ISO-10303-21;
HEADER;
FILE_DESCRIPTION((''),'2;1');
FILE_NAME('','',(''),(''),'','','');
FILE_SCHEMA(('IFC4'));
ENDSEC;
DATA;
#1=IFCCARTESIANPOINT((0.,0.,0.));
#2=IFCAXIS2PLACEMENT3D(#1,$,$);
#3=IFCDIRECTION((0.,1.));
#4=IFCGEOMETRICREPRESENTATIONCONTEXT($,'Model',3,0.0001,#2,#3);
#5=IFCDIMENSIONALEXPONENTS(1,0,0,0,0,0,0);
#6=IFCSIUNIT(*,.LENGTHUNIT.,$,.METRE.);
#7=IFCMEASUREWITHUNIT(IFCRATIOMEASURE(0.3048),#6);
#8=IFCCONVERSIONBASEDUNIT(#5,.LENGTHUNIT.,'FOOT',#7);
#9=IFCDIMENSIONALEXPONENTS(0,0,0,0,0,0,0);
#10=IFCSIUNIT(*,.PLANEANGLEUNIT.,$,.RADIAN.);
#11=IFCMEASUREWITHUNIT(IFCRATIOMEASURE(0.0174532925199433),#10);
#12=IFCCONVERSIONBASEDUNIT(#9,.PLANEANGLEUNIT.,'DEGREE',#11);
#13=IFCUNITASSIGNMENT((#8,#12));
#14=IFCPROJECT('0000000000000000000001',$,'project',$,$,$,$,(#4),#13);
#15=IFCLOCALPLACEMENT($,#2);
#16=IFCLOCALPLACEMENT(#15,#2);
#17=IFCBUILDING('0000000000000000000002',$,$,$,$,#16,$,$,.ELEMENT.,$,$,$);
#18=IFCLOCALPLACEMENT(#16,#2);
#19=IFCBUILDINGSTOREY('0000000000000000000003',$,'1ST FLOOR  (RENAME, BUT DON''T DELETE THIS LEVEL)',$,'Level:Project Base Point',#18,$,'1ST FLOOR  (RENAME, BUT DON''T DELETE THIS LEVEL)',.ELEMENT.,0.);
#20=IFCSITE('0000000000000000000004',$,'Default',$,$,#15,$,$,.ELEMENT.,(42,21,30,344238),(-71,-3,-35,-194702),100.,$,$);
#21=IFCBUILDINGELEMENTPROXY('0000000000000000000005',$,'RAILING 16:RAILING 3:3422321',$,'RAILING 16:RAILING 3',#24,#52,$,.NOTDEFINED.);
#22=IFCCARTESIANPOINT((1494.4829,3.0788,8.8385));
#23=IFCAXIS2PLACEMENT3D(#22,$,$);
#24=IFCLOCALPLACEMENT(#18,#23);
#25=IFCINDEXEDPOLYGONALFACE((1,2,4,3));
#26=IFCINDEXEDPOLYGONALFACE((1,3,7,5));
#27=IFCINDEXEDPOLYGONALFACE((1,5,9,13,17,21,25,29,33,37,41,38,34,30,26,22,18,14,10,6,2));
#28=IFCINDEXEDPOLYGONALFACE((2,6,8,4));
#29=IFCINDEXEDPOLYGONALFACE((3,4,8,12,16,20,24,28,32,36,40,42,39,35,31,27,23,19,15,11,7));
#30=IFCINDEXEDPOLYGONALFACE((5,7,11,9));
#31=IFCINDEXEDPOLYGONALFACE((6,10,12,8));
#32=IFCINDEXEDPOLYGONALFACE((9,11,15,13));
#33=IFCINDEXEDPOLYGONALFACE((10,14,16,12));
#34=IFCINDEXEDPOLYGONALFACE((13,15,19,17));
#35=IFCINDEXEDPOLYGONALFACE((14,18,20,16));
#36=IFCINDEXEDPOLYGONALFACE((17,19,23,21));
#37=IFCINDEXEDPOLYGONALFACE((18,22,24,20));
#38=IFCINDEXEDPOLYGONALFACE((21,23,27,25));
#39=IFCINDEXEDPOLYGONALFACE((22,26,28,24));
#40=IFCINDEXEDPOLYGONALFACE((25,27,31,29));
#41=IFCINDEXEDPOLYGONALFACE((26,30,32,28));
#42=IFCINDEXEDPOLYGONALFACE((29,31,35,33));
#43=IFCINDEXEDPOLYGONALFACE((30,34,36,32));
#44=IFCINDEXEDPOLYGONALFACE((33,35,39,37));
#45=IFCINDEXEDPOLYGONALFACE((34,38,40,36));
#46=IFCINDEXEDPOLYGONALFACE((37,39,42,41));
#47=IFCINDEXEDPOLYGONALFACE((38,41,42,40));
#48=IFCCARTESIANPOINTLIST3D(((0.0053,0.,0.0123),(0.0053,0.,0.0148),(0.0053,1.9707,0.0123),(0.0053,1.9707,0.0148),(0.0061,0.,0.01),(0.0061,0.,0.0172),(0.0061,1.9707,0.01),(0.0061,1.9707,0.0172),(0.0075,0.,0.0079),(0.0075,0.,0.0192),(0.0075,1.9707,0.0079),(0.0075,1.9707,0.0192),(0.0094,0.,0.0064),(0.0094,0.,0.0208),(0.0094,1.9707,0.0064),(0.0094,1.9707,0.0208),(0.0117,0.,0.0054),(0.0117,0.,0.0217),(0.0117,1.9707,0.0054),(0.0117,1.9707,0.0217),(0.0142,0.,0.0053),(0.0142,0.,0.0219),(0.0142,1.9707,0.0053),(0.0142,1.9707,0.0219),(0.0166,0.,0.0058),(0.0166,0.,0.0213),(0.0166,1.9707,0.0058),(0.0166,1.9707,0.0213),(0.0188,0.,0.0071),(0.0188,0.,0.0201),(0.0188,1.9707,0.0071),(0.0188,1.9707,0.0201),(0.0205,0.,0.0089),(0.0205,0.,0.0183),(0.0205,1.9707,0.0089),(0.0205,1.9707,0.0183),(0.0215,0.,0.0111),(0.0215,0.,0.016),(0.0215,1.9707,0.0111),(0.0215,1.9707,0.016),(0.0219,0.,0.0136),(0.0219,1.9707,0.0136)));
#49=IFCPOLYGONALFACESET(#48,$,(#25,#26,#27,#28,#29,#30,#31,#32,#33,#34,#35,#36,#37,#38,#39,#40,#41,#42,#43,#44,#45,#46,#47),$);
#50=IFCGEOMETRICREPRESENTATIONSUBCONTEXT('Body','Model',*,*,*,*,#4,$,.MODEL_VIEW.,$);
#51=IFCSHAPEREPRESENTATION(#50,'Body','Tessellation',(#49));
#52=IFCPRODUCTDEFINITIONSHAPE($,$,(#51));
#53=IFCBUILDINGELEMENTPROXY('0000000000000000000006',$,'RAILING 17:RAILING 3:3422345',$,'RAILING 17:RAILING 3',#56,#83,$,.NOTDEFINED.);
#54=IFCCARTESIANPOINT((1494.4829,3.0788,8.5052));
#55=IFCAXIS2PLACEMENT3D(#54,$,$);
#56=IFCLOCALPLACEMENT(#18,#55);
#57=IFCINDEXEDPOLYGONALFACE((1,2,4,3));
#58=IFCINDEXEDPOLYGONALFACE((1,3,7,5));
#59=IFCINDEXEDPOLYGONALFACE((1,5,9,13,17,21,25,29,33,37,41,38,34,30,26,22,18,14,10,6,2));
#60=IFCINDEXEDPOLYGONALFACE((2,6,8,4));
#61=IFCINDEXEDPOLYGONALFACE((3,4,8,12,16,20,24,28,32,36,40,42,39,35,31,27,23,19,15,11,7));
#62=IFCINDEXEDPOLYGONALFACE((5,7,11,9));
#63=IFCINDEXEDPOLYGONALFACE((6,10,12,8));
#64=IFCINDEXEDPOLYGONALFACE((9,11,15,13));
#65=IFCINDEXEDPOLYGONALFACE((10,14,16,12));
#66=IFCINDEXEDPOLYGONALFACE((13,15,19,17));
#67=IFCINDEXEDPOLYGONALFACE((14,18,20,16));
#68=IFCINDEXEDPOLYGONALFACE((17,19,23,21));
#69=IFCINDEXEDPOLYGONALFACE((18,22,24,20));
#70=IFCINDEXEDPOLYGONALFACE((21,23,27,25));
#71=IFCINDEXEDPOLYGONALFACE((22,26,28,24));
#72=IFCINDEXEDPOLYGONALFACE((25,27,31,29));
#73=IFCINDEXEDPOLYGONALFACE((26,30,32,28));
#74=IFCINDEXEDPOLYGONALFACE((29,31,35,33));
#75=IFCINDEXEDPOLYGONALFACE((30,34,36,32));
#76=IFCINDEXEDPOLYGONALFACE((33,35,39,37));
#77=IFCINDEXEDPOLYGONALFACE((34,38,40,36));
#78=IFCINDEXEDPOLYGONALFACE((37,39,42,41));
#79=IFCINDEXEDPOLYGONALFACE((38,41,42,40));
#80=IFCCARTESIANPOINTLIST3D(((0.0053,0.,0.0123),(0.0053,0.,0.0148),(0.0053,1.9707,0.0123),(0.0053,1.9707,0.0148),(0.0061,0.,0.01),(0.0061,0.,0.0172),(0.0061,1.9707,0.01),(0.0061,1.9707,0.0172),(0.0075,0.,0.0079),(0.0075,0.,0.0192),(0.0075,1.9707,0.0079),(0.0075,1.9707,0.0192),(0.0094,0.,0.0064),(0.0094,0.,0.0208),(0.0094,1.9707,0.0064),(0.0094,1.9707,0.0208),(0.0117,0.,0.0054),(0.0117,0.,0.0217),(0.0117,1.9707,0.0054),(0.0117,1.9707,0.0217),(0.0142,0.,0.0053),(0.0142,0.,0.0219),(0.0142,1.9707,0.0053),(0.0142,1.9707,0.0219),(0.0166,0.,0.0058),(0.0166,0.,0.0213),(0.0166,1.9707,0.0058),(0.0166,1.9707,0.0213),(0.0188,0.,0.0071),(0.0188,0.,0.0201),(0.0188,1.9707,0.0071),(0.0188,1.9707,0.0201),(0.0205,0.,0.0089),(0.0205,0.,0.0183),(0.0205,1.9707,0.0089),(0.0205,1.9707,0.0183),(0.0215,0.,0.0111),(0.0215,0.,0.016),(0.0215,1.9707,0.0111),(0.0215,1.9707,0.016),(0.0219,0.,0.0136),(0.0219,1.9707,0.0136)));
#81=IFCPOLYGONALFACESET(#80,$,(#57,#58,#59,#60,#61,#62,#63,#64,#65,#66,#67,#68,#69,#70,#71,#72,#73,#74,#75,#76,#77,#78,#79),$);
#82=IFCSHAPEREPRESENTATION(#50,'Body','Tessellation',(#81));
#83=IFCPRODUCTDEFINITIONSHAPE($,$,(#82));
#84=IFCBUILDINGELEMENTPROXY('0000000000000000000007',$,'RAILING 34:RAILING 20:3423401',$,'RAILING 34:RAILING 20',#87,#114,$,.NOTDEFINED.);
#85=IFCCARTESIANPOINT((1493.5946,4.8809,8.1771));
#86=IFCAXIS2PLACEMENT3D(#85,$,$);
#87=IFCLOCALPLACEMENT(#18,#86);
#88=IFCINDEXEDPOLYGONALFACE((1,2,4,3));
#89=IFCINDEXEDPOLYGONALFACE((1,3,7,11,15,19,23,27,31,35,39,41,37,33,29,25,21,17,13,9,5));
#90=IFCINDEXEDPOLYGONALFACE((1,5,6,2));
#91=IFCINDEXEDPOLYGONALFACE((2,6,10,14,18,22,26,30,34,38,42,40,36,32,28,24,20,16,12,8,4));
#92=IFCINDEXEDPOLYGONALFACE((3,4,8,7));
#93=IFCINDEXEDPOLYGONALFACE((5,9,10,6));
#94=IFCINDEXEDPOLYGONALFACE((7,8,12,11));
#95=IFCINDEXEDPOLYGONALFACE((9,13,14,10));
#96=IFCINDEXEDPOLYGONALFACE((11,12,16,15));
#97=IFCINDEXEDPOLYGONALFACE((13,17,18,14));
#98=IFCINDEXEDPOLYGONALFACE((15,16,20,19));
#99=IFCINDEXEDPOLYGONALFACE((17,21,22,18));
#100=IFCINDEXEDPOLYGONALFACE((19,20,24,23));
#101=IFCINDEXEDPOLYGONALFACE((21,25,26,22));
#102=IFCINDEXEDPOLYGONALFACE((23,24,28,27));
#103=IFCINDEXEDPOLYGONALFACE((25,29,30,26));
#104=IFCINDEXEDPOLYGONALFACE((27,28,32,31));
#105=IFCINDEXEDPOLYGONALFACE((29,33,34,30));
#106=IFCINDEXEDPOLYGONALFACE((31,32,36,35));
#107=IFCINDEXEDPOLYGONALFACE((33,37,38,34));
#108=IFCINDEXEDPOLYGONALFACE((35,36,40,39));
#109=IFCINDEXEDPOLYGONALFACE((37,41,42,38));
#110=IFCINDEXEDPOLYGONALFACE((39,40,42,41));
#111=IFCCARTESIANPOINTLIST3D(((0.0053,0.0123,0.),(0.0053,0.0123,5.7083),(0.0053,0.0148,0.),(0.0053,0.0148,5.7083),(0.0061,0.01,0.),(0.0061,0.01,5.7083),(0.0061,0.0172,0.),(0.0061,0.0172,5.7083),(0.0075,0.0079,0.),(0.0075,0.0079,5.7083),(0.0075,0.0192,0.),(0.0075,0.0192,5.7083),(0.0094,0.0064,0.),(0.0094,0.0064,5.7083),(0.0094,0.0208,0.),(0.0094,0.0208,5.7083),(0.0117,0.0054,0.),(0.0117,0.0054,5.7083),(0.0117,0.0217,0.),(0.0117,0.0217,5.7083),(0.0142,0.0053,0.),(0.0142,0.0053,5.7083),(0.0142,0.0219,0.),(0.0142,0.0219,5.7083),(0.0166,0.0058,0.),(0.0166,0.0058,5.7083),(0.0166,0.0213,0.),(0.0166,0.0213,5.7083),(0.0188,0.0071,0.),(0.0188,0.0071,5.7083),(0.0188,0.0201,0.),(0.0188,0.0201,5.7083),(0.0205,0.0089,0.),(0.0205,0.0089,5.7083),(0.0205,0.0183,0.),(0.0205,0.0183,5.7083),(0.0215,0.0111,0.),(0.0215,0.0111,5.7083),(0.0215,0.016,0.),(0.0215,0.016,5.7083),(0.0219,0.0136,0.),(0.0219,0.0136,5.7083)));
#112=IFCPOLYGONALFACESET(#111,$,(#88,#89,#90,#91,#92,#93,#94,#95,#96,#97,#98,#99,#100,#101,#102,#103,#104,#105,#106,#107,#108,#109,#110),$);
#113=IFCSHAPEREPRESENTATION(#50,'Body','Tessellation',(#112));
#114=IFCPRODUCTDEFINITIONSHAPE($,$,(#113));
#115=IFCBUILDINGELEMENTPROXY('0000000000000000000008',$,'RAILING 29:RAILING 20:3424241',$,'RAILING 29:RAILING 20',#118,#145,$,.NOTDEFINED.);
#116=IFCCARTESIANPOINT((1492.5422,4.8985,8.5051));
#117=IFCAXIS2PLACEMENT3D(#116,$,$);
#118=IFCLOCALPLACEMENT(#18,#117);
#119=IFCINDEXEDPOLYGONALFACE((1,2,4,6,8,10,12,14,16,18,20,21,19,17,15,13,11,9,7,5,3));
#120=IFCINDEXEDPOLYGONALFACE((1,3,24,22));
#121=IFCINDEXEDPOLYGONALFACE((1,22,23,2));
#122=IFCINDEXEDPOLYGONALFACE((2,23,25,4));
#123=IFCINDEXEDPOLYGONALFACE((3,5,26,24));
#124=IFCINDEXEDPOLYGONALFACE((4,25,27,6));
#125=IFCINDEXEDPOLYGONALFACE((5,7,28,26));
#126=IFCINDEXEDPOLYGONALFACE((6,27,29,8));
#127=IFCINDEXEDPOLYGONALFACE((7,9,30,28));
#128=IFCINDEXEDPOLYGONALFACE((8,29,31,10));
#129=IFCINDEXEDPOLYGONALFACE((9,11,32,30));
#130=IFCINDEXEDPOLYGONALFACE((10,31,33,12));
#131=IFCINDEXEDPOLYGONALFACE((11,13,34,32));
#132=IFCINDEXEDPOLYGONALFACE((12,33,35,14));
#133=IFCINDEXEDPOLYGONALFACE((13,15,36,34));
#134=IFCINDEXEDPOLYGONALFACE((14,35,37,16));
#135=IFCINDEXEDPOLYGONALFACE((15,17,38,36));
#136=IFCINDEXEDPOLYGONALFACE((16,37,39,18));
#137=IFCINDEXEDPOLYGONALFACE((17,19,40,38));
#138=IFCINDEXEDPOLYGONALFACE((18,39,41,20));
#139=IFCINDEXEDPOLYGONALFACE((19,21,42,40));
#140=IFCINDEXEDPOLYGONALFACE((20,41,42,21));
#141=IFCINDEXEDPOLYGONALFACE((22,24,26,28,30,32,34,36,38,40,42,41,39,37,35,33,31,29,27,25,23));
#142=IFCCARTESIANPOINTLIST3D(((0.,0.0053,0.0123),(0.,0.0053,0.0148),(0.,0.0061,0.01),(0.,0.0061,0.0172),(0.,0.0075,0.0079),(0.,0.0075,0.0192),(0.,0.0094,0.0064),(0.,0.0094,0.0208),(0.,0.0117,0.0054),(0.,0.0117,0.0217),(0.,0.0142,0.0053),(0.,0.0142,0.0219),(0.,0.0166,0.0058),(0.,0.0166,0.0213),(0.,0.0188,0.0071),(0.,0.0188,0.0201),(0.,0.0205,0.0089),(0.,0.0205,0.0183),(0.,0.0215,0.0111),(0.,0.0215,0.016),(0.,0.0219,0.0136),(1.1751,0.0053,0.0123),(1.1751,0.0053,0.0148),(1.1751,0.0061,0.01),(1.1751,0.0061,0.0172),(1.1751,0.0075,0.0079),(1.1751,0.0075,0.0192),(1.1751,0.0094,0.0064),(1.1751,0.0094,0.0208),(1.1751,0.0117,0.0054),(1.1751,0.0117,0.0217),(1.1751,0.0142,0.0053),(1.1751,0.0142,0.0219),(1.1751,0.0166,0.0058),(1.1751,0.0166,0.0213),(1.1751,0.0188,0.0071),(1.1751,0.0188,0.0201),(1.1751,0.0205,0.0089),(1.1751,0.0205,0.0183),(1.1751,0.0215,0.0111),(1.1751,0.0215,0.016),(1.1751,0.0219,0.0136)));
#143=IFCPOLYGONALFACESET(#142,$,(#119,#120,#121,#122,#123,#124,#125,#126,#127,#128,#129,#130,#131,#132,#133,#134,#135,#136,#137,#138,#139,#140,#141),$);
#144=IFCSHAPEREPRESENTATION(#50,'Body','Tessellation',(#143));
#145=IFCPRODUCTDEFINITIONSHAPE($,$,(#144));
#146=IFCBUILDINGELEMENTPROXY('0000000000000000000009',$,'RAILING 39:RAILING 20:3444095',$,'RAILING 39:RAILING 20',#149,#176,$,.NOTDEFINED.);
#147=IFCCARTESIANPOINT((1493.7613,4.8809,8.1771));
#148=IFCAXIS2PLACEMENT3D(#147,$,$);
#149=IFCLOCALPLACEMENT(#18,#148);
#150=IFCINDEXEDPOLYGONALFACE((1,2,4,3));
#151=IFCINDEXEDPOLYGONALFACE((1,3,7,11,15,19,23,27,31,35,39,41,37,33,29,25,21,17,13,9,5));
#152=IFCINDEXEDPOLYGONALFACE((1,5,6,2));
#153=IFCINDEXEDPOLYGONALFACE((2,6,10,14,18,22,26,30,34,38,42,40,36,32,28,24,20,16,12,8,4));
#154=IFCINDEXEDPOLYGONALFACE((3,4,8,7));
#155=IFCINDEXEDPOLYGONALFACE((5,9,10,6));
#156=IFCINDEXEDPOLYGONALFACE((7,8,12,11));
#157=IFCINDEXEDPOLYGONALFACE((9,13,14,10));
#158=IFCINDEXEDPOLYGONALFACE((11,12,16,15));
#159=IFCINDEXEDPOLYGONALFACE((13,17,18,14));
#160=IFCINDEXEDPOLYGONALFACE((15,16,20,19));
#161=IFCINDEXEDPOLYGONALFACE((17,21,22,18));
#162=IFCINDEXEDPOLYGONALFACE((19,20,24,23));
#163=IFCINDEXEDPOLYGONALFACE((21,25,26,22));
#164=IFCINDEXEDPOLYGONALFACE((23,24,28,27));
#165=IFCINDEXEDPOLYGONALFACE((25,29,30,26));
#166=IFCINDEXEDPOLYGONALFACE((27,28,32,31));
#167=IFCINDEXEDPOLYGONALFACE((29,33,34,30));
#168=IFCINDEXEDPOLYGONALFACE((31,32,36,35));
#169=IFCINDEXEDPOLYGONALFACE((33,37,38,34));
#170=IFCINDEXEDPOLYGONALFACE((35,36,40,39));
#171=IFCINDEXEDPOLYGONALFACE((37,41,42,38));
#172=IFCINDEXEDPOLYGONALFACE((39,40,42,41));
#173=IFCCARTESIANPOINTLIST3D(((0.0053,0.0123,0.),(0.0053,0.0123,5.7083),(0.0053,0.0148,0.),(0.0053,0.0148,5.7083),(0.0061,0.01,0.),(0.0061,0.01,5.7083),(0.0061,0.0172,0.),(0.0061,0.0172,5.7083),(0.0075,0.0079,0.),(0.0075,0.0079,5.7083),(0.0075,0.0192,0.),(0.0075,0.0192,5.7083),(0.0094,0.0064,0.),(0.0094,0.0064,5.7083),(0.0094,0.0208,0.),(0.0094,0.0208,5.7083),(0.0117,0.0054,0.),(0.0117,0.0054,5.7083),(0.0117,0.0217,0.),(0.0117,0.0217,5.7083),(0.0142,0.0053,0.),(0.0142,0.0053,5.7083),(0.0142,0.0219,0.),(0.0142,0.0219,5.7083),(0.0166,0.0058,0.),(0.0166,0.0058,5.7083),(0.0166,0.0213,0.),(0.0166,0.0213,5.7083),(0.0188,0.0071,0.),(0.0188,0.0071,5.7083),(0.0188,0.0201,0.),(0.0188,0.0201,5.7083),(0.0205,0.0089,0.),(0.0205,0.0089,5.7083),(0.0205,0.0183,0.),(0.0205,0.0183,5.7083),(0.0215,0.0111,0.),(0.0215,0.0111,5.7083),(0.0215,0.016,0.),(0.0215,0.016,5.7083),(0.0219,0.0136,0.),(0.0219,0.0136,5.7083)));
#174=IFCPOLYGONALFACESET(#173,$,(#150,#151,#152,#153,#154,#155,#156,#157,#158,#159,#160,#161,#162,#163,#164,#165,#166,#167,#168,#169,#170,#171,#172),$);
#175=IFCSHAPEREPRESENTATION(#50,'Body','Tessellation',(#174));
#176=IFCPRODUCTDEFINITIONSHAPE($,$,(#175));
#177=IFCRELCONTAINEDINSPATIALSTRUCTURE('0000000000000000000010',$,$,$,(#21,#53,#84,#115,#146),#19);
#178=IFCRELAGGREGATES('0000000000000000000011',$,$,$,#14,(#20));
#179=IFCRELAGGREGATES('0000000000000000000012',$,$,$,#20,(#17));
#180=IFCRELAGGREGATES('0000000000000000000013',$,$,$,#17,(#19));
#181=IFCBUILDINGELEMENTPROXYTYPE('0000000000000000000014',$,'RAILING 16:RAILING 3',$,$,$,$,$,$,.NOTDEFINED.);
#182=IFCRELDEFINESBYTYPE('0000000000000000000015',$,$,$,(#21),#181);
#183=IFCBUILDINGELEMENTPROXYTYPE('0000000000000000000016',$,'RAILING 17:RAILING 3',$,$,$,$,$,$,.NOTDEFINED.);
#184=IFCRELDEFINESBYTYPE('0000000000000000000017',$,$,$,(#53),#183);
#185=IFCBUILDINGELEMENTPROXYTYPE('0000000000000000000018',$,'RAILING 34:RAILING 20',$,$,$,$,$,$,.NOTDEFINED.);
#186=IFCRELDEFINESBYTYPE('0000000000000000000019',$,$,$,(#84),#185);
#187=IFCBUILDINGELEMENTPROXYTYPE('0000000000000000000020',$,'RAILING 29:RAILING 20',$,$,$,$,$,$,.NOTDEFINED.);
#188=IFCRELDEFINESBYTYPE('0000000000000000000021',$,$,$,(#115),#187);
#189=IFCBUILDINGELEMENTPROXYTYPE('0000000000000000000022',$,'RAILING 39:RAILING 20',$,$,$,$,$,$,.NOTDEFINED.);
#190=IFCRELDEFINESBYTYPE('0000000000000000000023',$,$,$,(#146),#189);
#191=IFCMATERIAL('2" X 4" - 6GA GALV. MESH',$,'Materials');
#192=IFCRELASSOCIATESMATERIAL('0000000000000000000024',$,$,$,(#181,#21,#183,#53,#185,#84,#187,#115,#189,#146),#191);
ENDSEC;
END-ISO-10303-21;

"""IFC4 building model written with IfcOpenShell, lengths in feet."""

from ifc_helpers import new_model, entity, si_unit, converted_unit, direction, frame, origin, origin_2d_with_axis, place, context, subcontext, project, spatial, circle, extrude, source, transform, mapped, material, type_object, type_shapes, element, save


model = new_model("IFC4")

# Units and contexts
model_context = context("Model", 3, precision=0.0001, world=origin(), true_north=direction((0.0, 1.0)))
body_context = subcontext(model_context, "Body", "Model", "MODEL_VIEW")
ifc_project = project(units=[converted_unit("LENGTHUNIT", "FOOT", entity("IfcRatioMeasure", 0.3048), si_unit("LENGTHUNIT", "METRE"), dimensions=[1, 0, 0, 0, 0, 0, 0]), converted_unit("PLANEANGLEUNIT", "DEGREE", entity("IfcRatioMeasure", 0.0174532925199433), si_unit("PLANEANGLEUNIT", "RADIAN"), dimensions=[0, 0, 0, 0, 0, 0, 0])], contexts=[model_context])

# Site, building, storey
site_placement = place(None, origin())
site = spatial("IfcSite", under=ifc_project, at=site_placement, Name="Default", CompositionType="ELEMENT", RefLatitude=(42, 21, 30, 344238), RefLongitude=(-71, -3, -35, -194702), RefElevation=100.0)
building_placement = place(site_placement, origin())
building = spatial("IfcBuilding", under=site, at=building_placement, CompositionType="ELEMENT")
storey_placement = place(building_placement, origin())
storey = spatial("IfcBuildingStorey", under=building, at=storey_placement, Name="1ST FLOOR  (RENAME, BUT DON'T DELETE THIS LEVEL)", ObjectType="Level:Project Base Point", LongName="1ST FLOOR  (RENAME, BUT DON'T DELETE THIS LEVEL)", CompositionType="ELEMENT", Elevation=0.0)

# Building element proxies
ifc_material_1 = material(Name="2\" X 4\" - 6GA GALV. MESH", Category="Materials")
building_element_proxy_type_1 = type_object("IfcBuildingElementProxyType", Name="RAILING 16:RAILING 3", PredefinedType="NOTDEFINED", material=ifc_material_1)
shared_shape_1 = source(origin(), body_context, "Body", "SweptSolid", [
    extrude(circle(Radius=0.0083, at=origin_2d_with_axis()), frame((0.0136, 0.0, 0.0136), z_axis=(0.0, 1.0, 0.0), x_axis=(1.0, 0.0, 0.0)), (0.0, 0.0, 1.0), 1.9707),
])
type_shapes(building_element_proxy_type_1, [shared_shape_1])
proxy_1_placement = place(storey_placement, frame((1494.4829, 3.0788, 8.8385)))
element("IfcBuildingElementProxy", 1, at=proxy_1_placement, inside=storey, type_object=building_element_proxy_type_1, material=ifc_material_1, Name="RAILING 16:RAILING 3:3422321", ObjectType="RAILING 16:RAILING 3", PredefinedType="NOTDEFINED", context=body_context, shape_type="MappedRepresentation", body=[
    mapped(shared_shape_1, transform((0.0, 0.0, 0.0), scale=1.0)),
])
building_element_proxy_type_2 = type_object("IfcBuildingElementProxyType", Name="RAILING 17:RAILING 3", PredefinedType="NOTDEFINED", material=ifc_material_1)
shared_shape_2 = source(origin(), body_context, "Body", "SweptSolid", [
    extrude(circle(Radius=0.0083, at=origin_2d_with_axis()), frame((0.0136, 0.0, 0.0136), z_axis=(0.0, 1.0, 0.0), x_axis=(1.0, 0.0, 0.0)), (0.0, 0.0, 1.0), 1.9707),
])
type_shapes(building_element_proxy_type_2, [shared_shape_2])
proxy_2_placement = place(storey_placement, frame((1494.4829, 3.0788, 8.5052)))
element("IfcBuildingElementProxy", 2, at=proxy_2_placement, inside=storey, type_object=building_element_proxy_type_2, material=ifc_material_1, Name="RAILING 17:RAILING 3:3422345", ObjectType="RAILING 17:RAILING 3", PredefinedType="NOTDEFINED", context=body_context, shape_type="MappedRepresentation", body=[
    mapped(shared_shape_2, transform((0.0, 0.0, 0.0), scale=1.0)),
])
building_element_proxy_type_3 = type_object("IfcBuildingElementProxyType", Name="RAILING 34:RAILING 20", PredefinedType="NOTDEFINED", material=ifc_material_1)
shared_shape_3 = source(origin(), body_context, "Body", "SweptSolid", [
    extrude(circle(Radius=0.0083, at=origin_2d_with_axis()), frame((0.0136, 0.0136, 0.0)), (0.0, 0.0, 1.0), 5.7083),
])
type_shapes(building_element_proxy_type_3, [shared_shape_3])
proxy_3_placement = place(storey_placement, frame((1493.5946, 4.8809, 8.1771)))
element("IfcBuildingElementProxy", 3, at=proxy_3_placement, inside=storey, type_object=building_element_proxy_type_3, material=ifc_material_1, Name="RAILING 34:RAILING 20:3423401", ObjectType="RAILING 34:RAILING 20", PredefinedType="NOTDEFINED", context=body_context, shape_type="MappedRepresentation", body=[
    mapped(shared_shape_3, transform((0.0, 0.0, 0.0), scale=1.0)),
])
building_element_proxy_type_4 = type_object("IfcBuildingElementProxyType", Name="RAILING 29:RAILING 20", PredefinedType="NOTDEFINED", material=ifc_material_1)
shared_shape_4 = source(origin(), body_context, "Body", "SweptSolid", [
    extrude(circle(Radius=0.0083, at=origin_2d_with_axis()), frame((0.0, 0.0136, 0.0136), z_axis=(1.0, 0.0, 0.0), x_axis=(0.0, 1.0, 0.0)), (0.0, 0.0, 1.0), 1.1751),
])
type_shapes(building_element_proxy_type_4, [shared_shape_4])
proxy_4_placement = place(storey_placement, frame((1492.5422, 4.8985, 8.5051)))
element("IfcBuildingElementProxy", 4, at=proxy_4_placement, inside=storey, type_object=building_element_proxy_type_4, material=ifc_material_1, Name="RAILING 29:RAILING 20:3424241", ObjectType="RAILING 29:RAILING 20", PredefinedType="NOTDEFINED", context=body_context, shape_type="MappedRepresentation", body=[
    mapped(shared_shape_4, transform((0.0, 0.0, 0.0), scale=1.0)),
])
building_element_proxy_type_5 = type_object("IfcBuildingElementProxyType", Name="RAILING 39:RAILING 20", PredefinedType="NOTDEFINED", material=ifc_material_1)
shared_shape_5 = source(origin(), body_context, "Body", "SweptSolid", [
    extrude(circle(Radius=0.0083, at=origin_2d_with_axis()), frame((0.0136, 0.0136, 0.0)), (0.0, 0.0, 1.0), 5.7083),
])
type_shapes(building_element_proxy_type_5, [shared_shape_5])
proxy_5_placement = place(storey_placement, frame((1493.7613, 4.8809, 8.1771)))
element("IfcBuildingElementProxy", 5, at=proxy_5_placement, inside=storey, type_object=building_element_proxy_type_5, material=ifc_material_1, Name="RAILING 39:RAILING 20:3444095", ObjectType="RAILING 39:RAILING 20", PredefinedType="NOTDEFINED", context=body_context, shape_type="MappedRepresentation", body=[
    mapped(shared_shape_5, transform((0.0, 0.0, 0.0), scale=1.0)),
])

save(model, "model.ifc")
